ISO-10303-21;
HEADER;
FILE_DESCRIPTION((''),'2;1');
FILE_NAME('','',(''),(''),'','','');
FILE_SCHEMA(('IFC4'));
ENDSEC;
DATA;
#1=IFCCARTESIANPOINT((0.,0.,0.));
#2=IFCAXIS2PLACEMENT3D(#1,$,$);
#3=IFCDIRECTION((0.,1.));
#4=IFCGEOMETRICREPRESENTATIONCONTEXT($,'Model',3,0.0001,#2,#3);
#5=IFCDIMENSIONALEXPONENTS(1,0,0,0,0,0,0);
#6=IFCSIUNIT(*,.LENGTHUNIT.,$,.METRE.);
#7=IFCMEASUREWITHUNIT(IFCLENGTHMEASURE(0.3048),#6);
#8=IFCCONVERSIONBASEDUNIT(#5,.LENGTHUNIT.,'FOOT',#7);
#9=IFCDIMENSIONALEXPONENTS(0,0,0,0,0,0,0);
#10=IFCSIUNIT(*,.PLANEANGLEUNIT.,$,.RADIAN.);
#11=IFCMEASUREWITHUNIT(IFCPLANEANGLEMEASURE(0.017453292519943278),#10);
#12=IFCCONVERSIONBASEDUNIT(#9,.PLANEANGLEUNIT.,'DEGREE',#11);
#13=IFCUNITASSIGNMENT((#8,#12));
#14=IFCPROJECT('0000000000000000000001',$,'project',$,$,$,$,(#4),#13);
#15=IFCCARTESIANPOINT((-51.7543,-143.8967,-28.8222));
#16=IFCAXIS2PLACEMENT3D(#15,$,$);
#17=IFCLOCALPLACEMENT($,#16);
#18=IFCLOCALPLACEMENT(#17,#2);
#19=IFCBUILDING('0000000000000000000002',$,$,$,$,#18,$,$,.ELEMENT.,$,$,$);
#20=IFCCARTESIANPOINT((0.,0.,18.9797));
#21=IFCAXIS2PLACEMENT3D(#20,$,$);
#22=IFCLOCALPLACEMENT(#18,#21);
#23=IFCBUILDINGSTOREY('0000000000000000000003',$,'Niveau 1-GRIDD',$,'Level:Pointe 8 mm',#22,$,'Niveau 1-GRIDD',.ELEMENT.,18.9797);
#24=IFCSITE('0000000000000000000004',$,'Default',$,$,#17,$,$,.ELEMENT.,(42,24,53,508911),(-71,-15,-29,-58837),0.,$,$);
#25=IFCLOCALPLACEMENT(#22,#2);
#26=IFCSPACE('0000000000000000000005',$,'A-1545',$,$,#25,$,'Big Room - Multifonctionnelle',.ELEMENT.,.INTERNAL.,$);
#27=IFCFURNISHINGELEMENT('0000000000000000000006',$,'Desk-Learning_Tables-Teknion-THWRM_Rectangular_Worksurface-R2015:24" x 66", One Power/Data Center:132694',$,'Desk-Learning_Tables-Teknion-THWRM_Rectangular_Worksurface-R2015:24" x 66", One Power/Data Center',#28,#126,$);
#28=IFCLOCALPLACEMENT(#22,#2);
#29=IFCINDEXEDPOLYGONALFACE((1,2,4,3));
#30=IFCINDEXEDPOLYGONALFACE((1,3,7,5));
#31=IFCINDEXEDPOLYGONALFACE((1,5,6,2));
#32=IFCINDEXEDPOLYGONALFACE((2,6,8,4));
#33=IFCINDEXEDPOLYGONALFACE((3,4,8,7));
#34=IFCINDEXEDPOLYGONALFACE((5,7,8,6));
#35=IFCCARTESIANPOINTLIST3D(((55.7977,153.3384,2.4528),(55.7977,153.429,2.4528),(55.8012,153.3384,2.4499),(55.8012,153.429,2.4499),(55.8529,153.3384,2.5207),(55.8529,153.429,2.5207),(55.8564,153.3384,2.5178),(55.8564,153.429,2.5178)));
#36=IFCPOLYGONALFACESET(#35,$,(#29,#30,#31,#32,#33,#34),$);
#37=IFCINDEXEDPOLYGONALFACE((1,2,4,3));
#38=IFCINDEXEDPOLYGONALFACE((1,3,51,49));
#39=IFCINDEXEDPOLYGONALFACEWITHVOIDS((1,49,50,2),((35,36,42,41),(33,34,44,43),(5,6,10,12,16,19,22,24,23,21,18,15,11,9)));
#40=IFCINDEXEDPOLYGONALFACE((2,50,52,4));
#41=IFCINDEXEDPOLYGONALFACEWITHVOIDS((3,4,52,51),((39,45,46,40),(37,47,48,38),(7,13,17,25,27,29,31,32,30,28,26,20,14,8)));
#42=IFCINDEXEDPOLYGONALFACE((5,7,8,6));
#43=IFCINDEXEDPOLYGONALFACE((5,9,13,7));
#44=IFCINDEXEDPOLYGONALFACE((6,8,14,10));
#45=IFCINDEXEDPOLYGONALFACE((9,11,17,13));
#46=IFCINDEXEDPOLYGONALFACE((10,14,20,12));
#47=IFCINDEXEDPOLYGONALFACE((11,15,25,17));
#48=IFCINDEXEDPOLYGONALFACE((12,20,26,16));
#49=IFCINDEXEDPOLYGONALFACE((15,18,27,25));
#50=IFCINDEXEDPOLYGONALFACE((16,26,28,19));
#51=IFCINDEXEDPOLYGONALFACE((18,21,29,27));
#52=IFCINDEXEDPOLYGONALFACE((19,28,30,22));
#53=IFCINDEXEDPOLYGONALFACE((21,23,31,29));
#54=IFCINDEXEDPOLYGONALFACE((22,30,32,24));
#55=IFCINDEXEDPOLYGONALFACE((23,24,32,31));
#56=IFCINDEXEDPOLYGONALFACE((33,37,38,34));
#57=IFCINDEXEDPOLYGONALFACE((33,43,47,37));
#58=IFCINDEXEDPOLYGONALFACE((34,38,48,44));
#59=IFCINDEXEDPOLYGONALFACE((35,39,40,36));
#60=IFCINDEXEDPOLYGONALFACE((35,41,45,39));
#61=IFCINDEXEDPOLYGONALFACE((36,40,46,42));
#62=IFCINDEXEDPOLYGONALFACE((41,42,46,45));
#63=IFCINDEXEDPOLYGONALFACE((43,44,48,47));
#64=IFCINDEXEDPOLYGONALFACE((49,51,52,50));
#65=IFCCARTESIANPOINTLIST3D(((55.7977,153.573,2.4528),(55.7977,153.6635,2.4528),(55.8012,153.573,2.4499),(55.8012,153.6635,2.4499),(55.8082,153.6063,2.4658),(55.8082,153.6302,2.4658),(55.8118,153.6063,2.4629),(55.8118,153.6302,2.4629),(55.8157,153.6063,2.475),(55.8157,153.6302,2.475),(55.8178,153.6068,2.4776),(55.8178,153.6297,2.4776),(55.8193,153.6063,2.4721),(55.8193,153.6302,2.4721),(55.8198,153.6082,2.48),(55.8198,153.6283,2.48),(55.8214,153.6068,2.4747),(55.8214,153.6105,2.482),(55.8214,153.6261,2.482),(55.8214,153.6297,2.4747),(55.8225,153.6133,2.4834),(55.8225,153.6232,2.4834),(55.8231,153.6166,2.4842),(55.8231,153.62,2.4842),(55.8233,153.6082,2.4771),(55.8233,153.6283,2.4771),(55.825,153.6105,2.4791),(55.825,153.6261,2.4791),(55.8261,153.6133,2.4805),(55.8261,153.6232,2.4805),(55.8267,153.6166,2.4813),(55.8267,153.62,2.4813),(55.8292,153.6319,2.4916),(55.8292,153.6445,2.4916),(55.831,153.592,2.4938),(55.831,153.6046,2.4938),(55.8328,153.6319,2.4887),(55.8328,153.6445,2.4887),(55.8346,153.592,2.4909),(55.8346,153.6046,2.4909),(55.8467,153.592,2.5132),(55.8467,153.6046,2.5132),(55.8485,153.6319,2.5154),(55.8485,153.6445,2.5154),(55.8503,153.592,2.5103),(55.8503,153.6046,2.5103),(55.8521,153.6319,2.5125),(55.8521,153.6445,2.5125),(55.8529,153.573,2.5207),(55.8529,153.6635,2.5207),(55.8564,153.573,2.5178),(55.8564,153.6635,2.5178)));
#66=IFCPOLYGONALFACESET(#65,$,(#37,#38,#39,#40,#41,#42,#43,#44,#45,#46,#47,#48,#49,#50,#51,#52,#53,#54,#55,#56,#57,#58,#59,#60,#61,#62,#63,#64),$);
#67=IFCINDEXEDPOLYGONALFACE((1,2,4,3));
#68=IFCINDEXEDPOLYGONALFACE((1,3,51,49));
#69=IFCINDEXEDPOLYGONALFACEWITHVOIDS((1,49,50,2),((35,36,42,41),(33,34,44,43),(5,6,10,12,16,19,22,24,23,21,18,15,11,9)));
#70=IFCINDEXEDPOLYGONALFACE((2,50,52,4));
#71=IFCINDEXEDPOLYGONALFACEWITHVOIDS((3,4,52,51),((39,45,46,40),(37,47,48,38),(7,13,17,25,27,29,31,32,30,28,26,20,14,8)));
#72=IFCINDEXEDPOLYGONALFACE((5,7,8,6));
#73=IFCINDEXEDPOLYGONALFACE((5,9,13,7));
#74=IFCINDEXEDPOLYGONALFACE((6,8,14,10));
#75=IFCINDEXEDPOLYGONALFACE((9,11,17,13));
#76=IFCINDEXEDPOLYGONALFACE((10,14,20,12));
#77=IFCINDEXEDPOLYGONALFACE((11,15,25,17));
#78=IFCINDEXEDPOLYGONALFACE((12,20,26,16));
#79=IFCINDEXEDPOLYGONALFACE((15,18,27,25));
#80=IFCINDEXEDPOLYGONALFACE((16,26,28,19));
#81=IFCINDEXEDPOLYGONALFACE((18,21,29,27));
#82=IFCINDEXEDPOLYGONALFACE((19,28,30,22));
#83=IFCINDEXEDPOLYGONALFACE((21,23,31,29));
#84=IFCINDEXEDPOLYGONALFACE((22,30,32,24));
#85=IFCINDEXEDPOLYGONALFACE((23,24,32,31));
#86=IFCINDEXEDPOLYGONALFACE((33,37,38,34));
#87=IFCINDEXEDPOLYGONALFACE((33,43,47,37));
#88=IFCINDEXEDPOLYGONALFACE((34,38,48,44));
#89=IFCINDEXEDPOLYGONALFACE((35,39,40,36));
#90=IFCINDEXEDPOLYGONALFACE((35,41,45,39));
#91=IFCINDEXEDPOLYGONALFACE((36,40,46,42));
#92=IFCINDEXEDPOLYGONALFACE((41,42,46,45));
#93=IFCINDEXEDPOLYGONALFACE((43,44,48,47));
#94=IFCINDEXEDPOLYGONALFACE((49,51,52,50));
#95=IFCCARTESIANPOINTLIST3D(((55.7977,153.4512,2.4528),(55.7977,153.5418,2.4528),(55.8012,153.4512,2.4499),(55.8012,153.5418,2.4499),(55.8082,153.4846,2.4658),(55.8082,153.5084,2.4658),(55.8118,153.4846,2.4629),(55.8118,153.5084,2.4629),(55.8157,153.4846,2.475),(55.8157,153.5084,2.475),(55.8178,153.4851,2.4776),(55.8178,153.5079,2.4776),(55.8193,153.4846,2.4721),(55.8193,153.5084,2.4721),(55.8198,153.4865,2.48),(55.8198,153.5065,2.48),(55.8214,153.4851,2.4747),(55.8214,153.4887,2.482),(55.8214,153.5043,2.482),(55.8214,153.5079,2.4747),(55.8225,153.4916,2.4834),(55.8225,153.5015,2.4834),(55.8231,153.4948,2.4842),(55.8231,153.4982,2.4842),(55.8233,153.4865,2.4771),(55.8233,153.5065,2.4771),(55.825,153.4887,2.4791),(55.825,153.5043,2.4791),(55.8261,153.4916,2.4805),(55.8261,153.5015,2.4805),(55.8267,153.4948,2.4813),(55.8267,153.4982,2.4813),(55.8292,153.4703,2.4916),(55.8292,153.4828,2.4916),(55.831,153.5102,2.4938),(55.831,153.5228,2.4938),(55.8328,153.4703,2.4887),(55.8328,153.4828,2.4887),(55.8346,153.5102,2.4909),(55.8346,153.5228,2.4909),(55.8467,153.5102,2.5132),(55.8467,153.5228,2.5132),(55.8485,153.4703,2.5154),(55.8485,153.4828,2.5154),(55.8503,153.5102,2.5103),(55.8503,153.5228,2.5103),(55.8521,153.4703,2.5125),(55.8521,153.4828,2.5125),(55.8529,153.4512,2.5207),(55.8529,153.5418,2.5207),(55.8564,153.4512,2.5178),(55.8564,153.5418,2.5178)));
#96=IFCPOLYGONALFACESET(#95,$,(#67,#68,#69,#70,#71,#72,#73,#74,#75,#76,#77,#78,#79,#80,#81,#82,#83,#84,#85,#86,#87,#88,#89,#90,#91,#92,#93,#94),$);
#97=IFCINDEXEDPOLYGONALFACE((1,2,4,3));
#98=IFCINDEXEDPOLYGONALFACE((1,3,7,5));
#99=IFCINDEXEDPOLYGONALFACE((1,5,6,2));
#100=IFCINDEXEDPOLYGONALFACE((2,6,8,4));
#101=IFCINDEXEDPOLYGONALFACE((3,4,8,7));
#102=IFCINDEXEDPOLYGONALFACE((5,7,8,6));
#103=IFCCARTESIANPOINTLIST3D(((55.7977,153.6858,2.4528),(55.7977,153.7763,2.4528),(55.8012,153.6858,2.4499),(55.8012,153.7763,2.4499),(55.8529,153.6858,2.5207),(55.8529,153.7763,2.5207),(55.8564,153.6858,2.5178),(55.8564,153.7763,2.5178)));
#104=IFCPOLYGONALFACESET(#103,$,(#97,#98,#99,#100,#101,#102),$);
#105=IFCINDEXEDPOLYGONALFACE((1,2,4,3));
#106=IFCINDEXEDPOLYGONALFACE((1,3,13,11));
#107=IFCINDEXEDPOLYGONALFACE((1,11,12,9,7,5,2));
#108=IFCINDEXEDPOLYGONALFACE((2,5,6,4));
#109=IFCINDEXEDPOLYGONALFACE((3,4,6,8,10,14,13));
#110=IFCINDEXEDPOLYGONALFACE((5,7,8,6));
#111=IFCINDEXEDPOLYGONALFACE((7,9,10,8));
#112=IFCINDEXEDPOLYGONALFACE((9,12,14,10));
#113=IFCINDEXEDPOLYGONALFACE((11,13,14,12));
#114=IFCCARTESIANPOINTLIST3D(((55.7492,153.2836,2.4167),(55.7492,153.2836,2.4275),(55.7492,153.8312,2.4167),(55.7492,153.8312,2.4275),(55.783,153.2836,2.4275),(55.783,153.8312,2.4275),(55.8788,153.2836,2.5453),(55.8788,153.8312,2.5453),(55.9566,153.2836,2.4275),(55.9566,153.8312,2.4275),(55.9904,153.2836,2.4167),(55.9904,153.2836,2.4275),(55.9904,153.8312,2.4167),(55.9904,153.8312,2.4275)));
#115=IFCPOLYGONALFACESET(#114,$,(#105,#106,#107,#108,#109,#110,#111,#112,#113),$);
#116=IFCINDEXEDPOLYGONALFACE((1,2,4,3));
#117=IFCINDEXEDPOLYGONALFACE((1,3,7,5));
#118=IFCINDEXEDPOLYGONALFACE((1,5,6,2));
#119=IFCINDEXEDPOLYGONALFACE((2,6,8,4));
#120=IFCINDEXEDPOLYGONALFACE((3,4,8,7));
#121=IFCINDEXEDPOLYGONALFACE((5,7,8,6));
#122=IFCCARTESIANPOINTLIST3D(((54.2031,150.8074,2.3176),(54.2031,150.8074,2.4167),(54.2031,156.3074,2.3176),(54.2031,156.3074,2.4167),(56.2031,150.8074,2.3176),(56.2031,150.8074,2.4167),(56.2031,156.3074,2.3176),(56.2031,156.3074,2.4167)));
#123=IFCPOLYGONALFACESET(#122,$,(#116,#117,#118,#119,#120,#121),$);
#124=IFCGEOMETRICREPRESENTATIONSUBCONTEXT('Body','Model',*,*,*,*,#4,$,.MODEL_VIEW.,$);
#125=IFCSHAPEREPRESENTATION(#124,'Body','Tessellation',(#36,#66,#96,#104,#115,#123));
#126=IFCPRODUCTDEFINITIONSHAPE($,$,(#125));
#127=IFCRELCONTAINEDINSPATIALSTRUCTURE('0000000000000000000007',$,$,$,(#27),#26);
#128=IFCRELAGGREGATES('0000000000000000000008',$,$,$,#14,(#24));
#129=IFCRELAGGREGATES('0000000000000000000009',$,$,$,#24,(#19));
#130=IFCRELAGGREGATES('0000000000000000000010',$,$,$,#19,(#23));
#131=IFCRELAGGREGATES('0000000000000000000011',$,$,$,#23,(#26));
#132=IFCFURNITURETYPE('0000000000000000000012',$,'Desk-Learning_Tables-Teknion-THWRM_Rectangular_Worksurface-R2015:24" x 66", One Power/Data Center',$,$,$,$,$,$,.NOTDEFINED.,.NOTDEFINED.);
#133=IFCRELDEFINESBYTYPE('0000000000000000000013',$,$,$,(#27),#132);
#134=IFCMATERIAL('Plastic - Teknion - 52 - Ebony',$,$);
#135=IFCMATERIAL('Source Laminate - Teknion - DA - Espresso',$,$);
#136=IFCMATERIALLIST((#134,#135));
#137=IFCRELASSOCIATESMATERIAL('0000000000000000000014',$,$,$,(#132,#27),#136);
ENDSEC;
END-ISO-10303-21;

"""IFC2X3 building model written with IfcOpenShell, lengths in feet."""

from ifc_helpers import new_model, entity, si_unit, converted_unit, direction, frame, frame_2d, origin, place, context, subcontext, project, spatial, polyline, circle_curve, parameter, trimmed, segment, composite_curve, rectangle, outline, extrude, source, transform, mapped, material, material_list, type_object, type_shapes, element, save


model = new_model("IFC2X3")

# Units and contexts
model_context = context("Model", 3, precision=0.0001, world=origin(), true_north=direction((0.0, 1.0)))
body_context = subcontext(model_context, "Body", "Model", "MODEL_VIEW")
ifc_project = project(units=[converted_unit("LENGTHUNIT", "FOOT", entity("IfcLengthMeasure", 0.3048), si_unit("LENGTHUNIT", "METRE"), dimensions=[1, 0, 0, 0, 0, 0, 0]), converted_unit("PLANEANGLEUNIT", "DEGREE", entity("IfcPlaneAngleMeasure", 0.017453292519943278), si_unit("PLANEANGLEUNIT", "RADIAN"), dimensions=[0, 0, 0, 0, 0, 0, 0])], contexts=[model_context])

# Site, building, storey
site_placement = place(None, frame((-51.7543, -143.8967, -28.8222)))
site = spatial("IfcSite", under=ifc_project, at=site_placement, Name="Default", CompositionType="ELEMENT", RefLatitude=(42, 24, 53, 508911), RefLongitude=(-71, -15, -29, -58837), RefElevation=0.0)
building_placement = place(site_placement, origin())
building = spatial("IfcBuilding", under=site, at=building_placement, CompositionType="ELEMENT")
storey_placement = place(building_placement, frame((0.0, 0.0, 18.9797)))
storey = spatial("IfcBuildingStorey", under=building, at=storey_placement, Name="Niveau 1-GRIDD", ObjectType="Level:Pointe 8 mm", LongName="Niveau 1-GRIDD", CompositionType="ELEMENT", Elevation=18.9797)

# Shared definitions
space_placement = place(storey_placement, origin())
space = spatial("IfcSpace", under=storey, at=space_placement, Name="A-1545", LongName="Big Room - Multifonctionnelle", CompositionType="ELEMENT", InteriorOrExteriorSpace="INTERNAL")

# Furnishing element
ifc_material_1 = material(Name="Plastic - Teknion - 52 - Ebony")
ifc_material_2 = material(Name="Source Laminate - Teknion - DA - Espresso")
ifc_material_list_1 = material_list([ifc_material_1, ifc_material_2])
furniture_type_1 = type_object("IfcFurnitureType", Name="Desk-Learning_Tables-Teknion-THWRM_Rectangular_Worksurface-R2015:24\" x 66\", One Power/Data Center", AssemblyPlace="NOTDEFINED", material=ifc_material_list_1)
shared_shape_1 = source(origin(), body_context, "Body", "SweptSolid", [
    extrude(rectangle(XDim=0.0875, YDim=0.0046, at=frame_2d((0.0, 0.0), x_axis=(0.0, 1.0))), frame((0.1284, 0.6239, 2.4853), z_axis=(1.0, 0.0, 0.0), x_axis=(0.0, 0.776046, -0.630676)), (0.0, 0.0, 1.0), 0.0906),
    extrude(outline(polyline([(-0.0453, -0.0438), (0.0453, -0.0438), (0.0453, 0.0438), (-0.0453, 0.0438), (-0.0453, -0.0438)]), holes=[polyline([(-0.0262, -0.0063), (-0.0137, -0.0063), (-0.0137, -0.0369), (-0.0262, -0.0369), (-0.0262, -0.0063)]), polyline([(0.0137, -0.0341), (0.0137, -0.0091), (0.0262, -0.0091), (0.0262, -0.0341), (0.0137, -0.0341)]), composite_curve([segment(polyline([(-0.0119, 0.027), (0.0119, 0.027)]), True, "CONTINUOUS"), segment(polyline([(0.0119, 0.027), (0.0119, 0.0151)]), True, "CONTINUOUS"), segment(trimmed(circle_curve(frame_2d((0.0, 0.0151), x_axis=(0.0, -1.0)), 0.0119), [parameter(270.0)], [parameter(90.0)], True, "PARAMETER"), False, "CONTINUOUS"), segment(polyline([(-0.0119, 0.0151), (-0.0119, 0.027)]), True, "CONTINUOUS")], self_intersect=False)]), frame((-0.0609, 0.6221, 2.4867), z_axis=(0.0, 0.776046, -0.630676), x_axis=(1.0, 0.0, 0.0)), (0.0, 0.0, 1.0), 0.0046),
    extrude(outline(polyline([(-0.0438, -0.0453), (0.0438, -0.0453), (0.0438, 0.0453), (-0.0438, 0.0453), (-0.0438, -0.0453)]), holes=[polyline([(-0.0063, -0.0262), (-0.0369, -0.0262), (-0.0369, -0.0137), (-0.0063, -0.0137), (-0.0063, -0.0262)]), polyline([(-0.0341, 0.0137), (-0.0341, 0.0262), (-0.0091, 0.0262), (-0.0091, 0.0137), (-0.0341, 0.0137)]), composite_curve([segment(polyline([(0.027, -0.0119), (0.0151, -0.0119)]), True, "CONTINUOUS"), segment(trimmed(circle_curve(frame_2d((0.0151, 0.0), x_axis=(-1.0, 0.0)), 0.0119), [parameter(270.0)], [parameter(90.0)], True, "PARAMETER"), False, "CONTINUOUS"), segment(polyline([(0.0151, 0.0119), (0.027, 0.0119)]), True, "CONTINUOUS"), segment(polyline([(0.027, 0.0119), (0.027, -0.0119)]), True, "CONTINUOUS")], self_intersect=False)]), frame((0.0609, 0.6221, 2.4867), z_axis=(0.0, 0.776046, -0.630676), x_axis=(0.0, -0.630676, -0.776046)), (0.0, 0.0, 1.0), 0.0046),
    extrude(rectangle(XDim=0.0875, YDim=0.0046, at=frame_2d((0.0, 0.0), x_axis=(0.0, 1.0))), frame((-0.219, 0.6239, 2.4853), z_axis=(1.0, 0.0, 0.0), x_axis=(0.0, 0.776046, -0.630676)), (0.0, 0.0, 1.0), 0.0906),
    extrude(outline(polyline([(-0.0586, -0.0638), (0.0826, -0.0638), (0.0371, 0.0811), (0.0557, 0.1093), (0.0467, 0.1152), (-0.0862, -0.086), (-0.0772, -0.092), (-0.0586, -0.0638)])), frame((-0.2738, 0.6679, 2.4412), z_axis=(1.0, 0.0, 0.0), x_axis=(0.0, -0.551103, 0.834437)), (0.0, 0.0, 1.0), 0.5475),
    extrude(rectangle(XDim=5.5, YDim=2.0, at=frame_2d((0.0, 0.0), x_axis=(1.0, 0.0))), frame((0.0, 0.0, 2.3176), z_axis=(0.0, 0.0, 1.0), x_axis=(-1.0, 0.0, 0.0)), (0.0, 0.0, 1.0), 0.0991),
])
type_shapes(furniture_type_1, [shared_shape_1])
for number, where, z_axis, x_axis, name in (
    (1, (55.2031, 153.5574, 0.0), (0.0, 0.0, 1.0), (0.0, -1.0, 0.0), "Desk-Learning_Tables-Teknion-THWRM_Rectangular_Worksurface-R2015:24\" x 66\", One Power/Data Center:132694"),
):
    element("IfcFurnishingElement", number, at=place(space_placement, frame(where, z_axis=z_axis, x_axis=x_axis)), inside=space, type_object=furniture_type_1, material=ifc_material_list_1, Name=name, ObjectType="Desk-Learning_Tables-Teknion-THWRM_Rectangular_Worksurface-R2015:24\" x 66\", One Power/Data Center", context=body_context, shape_type="MappedRepresentation", body=[
        mapped(shared_shape_1, transform((0.0, 0.0, 0.0), scale=1.0)),
    ])

save(model, "model.ifc")
